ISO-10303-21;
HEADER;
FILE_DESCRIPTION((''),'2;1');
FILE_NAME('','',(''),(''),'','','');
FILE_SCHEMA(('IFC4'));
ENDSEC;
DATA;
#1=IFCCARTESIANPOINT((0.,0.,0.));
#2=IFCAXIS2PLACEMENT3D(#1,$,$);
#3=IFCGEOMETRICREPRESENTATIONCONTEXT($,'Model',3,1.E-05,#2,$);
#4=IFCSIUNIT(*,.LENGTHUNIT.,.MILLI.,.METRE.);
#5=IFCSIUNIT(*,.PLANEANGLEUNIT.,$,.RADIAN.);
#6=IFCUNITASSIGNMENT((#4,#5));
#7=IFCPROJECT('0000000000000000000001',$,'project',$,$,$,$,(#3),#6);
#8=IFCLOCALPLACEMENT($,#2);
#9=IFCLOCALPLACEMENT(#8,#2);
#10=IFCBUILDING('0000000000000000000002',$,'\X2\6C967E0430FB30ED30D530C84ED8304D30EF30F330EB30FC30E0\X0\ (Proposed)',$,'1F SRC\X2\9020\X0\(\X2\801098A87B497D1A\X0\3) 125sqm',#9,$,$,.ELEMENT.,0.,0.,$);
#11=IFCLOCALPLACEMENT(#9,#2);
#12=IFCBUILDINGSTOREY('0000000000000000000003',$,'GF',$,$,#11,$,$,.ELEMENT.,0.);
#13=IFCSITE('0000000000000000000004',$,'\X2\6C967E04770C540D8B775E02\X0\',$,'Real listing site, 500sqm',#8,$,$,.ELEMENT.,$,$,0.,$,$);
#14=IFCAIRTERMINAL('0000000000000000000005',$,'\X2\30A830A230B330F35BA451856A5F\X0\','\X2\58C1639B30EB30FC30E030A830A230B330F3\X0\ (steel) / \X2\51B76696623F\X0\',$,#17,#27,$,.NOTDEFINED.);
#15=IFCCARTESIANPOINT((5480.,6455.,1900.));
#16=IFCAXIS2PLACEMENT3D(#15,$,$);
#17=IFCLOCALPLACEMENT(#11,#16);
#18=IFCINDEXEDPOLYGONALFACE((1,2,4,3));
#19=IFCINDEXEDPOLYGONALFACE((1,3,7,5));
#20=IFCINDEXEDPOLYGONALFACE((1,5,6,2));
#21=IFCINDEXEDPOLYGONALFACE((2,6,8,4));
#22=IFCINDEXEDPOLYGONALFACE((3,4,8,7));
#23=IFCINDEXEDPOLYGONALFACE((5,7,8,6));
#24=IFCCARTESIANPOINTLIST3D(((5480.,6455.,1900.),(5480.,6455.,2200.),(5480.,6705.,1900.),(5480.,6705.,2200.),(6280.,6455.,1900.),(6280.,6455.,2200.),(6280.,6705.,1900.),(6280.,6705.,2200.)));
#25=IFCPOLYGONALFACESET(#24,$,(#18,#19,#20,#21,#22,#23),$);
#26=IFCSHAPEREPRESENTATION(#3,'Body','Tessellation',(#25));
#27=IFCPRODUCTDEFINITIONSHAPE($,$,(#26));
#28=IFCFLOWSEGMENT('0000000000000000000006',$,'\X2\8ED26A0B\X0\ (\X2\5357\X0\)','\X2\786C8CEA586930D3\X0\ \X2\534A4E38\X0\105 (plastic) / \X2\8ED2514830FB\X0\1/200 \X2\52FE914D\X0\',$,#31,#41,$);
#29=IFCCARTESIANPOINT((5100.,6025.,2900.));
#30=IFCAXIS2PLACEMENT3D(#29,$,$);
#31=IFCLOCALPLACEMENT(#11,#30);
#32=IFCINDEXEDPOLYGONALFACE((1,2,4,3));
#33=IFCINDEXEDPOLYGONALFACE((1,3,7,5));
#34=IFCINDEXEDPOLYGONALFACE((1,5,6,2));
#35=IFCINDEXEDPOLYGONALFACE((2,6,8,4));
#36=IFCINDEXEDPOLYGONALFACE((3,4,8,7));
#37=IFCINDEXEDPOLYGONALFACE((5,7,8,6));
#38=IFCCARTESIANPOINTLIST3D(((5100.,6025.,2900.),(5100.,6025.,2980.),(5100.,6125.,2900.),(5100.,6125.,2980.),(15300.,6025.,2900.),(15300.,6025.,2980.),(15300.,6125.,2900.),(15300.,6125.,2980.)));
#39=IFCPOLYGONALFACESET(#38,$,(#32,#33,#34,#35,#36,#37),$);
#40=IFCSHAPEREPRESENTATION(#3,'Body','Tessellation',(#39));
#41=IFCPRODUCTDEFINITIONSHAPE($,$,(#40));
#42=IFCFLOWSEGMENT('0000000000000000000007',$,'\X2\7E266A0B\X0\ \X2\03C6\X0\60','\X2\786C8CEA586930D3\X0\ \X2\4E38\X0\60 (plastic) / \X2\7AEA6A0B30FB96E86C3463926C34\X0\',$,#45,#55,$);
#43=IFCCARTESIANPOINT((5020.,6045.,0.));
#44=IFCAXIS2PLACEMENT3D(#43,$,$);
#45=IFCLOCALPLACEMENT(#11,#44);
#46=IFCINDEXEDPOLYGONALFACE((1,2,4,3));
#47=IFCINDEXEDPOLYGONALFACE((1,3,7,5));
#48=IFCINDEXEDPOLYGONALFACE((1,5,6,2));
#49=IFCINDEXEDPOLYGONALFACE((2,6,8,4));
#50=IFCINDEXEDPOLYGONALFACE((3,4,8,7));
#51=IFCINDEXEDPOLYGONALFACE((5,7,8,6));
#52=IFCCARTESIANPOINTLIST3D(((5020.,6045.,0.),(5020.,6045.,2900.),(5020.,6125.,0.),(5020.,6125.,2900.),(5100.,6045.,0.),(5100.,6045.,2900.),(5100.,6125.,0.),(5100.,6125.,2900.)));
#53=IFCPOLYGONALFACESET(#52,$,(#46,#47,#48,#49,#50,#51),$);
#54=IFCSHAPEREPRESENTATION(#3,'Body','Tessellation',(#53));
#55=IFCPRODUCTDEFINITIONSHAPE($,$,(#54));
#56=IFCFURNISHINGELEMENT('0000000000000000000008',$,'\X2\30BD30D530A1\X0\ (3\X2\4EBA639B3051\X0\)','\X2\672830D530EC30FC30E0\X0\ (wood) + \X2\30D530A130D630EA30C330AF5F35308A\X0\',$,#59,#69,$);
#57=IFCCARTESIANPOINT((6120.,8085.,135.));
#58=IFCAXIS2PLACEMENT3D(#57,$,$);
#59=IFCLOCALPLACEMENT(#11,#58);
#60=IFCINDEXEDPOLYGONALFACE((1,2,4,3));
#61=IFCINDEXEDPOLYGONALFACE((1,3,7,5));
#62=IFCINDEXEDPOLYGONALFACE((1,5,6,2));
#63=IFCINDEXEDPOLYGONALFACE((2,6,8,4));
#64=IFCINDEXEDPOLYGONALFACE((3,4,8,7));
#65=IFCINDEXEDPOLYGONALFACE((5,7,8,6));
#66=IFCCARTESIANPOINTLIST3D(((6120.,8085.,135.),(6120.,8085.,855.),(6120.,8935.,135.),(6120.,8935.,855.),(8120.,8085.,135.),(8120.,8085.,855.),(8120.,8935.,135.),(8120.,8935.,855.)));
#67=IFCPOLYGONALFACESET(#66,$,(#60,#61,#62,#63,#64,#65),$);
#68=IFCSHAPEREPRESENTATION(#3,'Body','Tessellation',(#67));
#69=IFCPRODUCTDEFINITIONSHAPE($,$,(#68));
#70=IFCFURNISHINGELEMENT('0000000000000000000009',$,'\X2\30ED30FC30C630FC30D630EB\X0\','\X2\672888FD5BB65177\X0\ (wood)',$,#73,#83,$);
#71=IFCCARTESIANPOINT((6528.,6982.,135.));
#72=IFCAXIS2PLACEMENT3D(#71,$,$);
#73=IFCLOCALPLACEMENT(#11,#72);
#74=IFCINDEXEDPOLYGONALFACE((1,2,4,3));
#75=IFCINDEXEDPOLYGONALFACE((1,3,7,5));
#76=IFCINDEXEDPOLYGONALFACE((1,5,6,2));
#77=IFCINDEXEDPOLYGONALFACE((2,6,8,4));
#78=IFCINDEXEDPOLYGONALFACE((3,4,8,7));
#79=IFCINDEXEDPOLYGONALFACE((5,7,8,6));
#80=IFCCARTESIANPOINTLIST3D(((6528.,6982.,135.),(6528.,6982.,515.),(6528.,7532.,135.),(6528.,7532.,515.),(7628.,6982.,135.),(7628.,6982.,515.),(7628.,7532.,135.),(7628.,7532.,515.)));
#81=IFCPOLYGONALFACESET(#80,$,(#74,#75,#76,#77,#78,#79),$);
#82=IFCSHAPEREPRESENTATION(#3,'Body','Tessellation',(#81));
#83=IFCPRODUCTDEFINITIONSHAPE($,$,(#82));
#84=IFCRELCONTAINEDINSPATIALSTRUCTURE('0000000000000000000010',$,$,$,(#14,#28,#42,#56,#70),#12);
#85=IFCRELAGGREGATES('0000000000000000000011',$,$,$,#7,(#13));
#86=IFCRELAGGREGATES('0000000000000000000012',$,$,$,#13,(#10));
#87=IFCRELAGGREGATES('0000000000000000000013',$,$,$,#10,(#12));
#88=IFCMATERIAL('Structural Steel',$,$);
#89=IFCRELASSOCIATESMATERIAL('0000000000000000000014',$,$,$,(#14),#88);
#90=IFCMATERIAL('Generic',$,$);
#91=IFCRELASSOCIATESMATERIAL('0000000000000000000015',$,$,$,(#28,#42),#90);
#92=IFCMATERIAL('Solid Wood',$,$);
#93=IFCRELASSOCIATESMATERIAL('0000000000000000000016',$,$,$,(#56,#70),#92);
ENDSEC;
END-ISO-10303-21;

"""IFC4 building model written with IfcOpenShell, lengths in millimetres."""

from ifc_helpers import new_model, si_unit, frame, frame_2d, origin, place, context, project, spatial, rectangle, extrude, material, element, save


model = new_model("IFC4")

# Units and contexts
model_context = context("Model", 3, precision=1e-05, world=origin())
ifc_project = project(units=[si_unit("LENGTHUNIT", "METRE", prefix="MILLI"), si_unit("PLANEANGLEUNIT", "RADIAN")], contexts=[model_context])

# Site, building, storey
site_placement = place(None, origin())
site = spatial("IfcSite", under=ifc_project, at=site_placement, Name="沖縄県名護市", ObjectType="Real listing site, 500sqm", CompositionType="ELEMENT", RefElevation=0.0)
building_placement = place(site_placement, origin())
building = spatial("IfcBuilding", under=site, at=building_placement, Name="沖縄・ロフト付きワンルーム (Proposed)", ObjectType="1F SRC造(耐風等級3) 125sqm", CompositionType="ELEMENT", ElevationOfRefHeight=0.0, ElevationOfTerrain=0.0)
storey_placement = place(building_placement, origin())
storey = spatial("IfcBuildingStorey", under=building, at=storey_placement, Name="GF", CompositionType="ELEMENT", Elevation=0.0)

# Shared definitions
ifc_material_1 = material(Name="Solid Wood")

# Shared definitions
ifc_material_2 = material(Name="Structural Steel")

# Shared definitions
ifc_material_3 = material(Name="Generic")

# Air terminal
air_terminal_placement = place(storey_placement, frame((5480.0, 6455.0, 1900.0)))
element("IfcAirTerminal", 1, at=air_terminal_placement, inside=storey, material=ifc_material_2, Name="エアコン室内機", Description="壁掛ルームエアコン (steel) / 冷暖房", PredefinedType="NOTDEFINED", context=model_context, shape_type="SweptSolid", body=[
    extrude(rectangle(XDim=800.0, YDim=250.0, at=frame_2d((400.0, 125.0))), frame((5480.0, 6455.0, 1900.0)), (0.0, 0.0, 1.0), 300.0),
])

# Flow segments
flow_segment_1_placement = place(storey_placement, frame((5100.0, 6025.0, 2900.0)))
element("IfcFlowSegment", 2, at=flow_segment_1_placement, inside=storey, material=ifc_material_3, Name="軒樋 (南)", Description="硬質塩ビ 半丸105 (plastic) / 軒先・1/200 勾配", context=model_context, shape_type="SweptSolid", body=[
    extrude(rectangle(XDim=10200.0, YDim=100.0, at=frame_2d((5100.0, 50.0))), frame((5100.0, 6025.0, 2900.0)), (0.0, 0.0, 1.0), 80.0),
])
flow_segment_2_placement = place(storey_placement, frame((5020.0, 6045.0, 0.0)))
element("IfcFlowSegment", 3, at=flow_segment_2_placement, inside=storey, material=ifc_material_3, Name="縦樋 φ60", Description="硬質塩ビ 丸60 (plastic) / 竪樋・雨水排水", context=model_context, shape_type="SweptSolid", body=[
    extrude(rectangle(XDim=80.0, YDim=80.0, at=frame_2d((40.0, 40.0))), frame((5020.0, 6045.0, 0.0)), (0.0, 0.0, 1.0), 2900.0),
])

# Furnishing elements
furnishing_1_placement = place(storey_placement, frame((6120.0, 8085.0, 135.0)))
element("IfcFurnishingElement", 4, at=furnishing_1_placement, inside=storey, material=ifc_material_1, Name="ソファ (3人掛け)", Description="木フレーム (wood) + ファブリック張り", context=model_context, shape_type="SweptSolid", body=[
    extrude(rectangle(XDim=2000.0, YDim=850.0, at=frame_2d((1000.0, 425.0))), frame((6120.0, 8085.0, 135.0)), (0.0, 0.0, 1.0), 720.0),
])
furnishing_2_placement = place(storey_placement, frame((6528.0, 6982.0, 135.0)))
element("IfcFurnishingElement", 5, at=furnishing_2_placement, inside=storey, material=ifc_material_1, Name="ローテーブル", Description="木製家具 (wood)", context=model_context, shape_type="SweptSolid", body=[
    extrude(rectangle(XDim=1100.0, YDim=550.0, at=frame_2d((550.0, 275.0))), frame((6528.0, 6982.0, 135.0)), (0.0, 0.0, 1.0), 380.0),
])

save(model, "model.ifc")
